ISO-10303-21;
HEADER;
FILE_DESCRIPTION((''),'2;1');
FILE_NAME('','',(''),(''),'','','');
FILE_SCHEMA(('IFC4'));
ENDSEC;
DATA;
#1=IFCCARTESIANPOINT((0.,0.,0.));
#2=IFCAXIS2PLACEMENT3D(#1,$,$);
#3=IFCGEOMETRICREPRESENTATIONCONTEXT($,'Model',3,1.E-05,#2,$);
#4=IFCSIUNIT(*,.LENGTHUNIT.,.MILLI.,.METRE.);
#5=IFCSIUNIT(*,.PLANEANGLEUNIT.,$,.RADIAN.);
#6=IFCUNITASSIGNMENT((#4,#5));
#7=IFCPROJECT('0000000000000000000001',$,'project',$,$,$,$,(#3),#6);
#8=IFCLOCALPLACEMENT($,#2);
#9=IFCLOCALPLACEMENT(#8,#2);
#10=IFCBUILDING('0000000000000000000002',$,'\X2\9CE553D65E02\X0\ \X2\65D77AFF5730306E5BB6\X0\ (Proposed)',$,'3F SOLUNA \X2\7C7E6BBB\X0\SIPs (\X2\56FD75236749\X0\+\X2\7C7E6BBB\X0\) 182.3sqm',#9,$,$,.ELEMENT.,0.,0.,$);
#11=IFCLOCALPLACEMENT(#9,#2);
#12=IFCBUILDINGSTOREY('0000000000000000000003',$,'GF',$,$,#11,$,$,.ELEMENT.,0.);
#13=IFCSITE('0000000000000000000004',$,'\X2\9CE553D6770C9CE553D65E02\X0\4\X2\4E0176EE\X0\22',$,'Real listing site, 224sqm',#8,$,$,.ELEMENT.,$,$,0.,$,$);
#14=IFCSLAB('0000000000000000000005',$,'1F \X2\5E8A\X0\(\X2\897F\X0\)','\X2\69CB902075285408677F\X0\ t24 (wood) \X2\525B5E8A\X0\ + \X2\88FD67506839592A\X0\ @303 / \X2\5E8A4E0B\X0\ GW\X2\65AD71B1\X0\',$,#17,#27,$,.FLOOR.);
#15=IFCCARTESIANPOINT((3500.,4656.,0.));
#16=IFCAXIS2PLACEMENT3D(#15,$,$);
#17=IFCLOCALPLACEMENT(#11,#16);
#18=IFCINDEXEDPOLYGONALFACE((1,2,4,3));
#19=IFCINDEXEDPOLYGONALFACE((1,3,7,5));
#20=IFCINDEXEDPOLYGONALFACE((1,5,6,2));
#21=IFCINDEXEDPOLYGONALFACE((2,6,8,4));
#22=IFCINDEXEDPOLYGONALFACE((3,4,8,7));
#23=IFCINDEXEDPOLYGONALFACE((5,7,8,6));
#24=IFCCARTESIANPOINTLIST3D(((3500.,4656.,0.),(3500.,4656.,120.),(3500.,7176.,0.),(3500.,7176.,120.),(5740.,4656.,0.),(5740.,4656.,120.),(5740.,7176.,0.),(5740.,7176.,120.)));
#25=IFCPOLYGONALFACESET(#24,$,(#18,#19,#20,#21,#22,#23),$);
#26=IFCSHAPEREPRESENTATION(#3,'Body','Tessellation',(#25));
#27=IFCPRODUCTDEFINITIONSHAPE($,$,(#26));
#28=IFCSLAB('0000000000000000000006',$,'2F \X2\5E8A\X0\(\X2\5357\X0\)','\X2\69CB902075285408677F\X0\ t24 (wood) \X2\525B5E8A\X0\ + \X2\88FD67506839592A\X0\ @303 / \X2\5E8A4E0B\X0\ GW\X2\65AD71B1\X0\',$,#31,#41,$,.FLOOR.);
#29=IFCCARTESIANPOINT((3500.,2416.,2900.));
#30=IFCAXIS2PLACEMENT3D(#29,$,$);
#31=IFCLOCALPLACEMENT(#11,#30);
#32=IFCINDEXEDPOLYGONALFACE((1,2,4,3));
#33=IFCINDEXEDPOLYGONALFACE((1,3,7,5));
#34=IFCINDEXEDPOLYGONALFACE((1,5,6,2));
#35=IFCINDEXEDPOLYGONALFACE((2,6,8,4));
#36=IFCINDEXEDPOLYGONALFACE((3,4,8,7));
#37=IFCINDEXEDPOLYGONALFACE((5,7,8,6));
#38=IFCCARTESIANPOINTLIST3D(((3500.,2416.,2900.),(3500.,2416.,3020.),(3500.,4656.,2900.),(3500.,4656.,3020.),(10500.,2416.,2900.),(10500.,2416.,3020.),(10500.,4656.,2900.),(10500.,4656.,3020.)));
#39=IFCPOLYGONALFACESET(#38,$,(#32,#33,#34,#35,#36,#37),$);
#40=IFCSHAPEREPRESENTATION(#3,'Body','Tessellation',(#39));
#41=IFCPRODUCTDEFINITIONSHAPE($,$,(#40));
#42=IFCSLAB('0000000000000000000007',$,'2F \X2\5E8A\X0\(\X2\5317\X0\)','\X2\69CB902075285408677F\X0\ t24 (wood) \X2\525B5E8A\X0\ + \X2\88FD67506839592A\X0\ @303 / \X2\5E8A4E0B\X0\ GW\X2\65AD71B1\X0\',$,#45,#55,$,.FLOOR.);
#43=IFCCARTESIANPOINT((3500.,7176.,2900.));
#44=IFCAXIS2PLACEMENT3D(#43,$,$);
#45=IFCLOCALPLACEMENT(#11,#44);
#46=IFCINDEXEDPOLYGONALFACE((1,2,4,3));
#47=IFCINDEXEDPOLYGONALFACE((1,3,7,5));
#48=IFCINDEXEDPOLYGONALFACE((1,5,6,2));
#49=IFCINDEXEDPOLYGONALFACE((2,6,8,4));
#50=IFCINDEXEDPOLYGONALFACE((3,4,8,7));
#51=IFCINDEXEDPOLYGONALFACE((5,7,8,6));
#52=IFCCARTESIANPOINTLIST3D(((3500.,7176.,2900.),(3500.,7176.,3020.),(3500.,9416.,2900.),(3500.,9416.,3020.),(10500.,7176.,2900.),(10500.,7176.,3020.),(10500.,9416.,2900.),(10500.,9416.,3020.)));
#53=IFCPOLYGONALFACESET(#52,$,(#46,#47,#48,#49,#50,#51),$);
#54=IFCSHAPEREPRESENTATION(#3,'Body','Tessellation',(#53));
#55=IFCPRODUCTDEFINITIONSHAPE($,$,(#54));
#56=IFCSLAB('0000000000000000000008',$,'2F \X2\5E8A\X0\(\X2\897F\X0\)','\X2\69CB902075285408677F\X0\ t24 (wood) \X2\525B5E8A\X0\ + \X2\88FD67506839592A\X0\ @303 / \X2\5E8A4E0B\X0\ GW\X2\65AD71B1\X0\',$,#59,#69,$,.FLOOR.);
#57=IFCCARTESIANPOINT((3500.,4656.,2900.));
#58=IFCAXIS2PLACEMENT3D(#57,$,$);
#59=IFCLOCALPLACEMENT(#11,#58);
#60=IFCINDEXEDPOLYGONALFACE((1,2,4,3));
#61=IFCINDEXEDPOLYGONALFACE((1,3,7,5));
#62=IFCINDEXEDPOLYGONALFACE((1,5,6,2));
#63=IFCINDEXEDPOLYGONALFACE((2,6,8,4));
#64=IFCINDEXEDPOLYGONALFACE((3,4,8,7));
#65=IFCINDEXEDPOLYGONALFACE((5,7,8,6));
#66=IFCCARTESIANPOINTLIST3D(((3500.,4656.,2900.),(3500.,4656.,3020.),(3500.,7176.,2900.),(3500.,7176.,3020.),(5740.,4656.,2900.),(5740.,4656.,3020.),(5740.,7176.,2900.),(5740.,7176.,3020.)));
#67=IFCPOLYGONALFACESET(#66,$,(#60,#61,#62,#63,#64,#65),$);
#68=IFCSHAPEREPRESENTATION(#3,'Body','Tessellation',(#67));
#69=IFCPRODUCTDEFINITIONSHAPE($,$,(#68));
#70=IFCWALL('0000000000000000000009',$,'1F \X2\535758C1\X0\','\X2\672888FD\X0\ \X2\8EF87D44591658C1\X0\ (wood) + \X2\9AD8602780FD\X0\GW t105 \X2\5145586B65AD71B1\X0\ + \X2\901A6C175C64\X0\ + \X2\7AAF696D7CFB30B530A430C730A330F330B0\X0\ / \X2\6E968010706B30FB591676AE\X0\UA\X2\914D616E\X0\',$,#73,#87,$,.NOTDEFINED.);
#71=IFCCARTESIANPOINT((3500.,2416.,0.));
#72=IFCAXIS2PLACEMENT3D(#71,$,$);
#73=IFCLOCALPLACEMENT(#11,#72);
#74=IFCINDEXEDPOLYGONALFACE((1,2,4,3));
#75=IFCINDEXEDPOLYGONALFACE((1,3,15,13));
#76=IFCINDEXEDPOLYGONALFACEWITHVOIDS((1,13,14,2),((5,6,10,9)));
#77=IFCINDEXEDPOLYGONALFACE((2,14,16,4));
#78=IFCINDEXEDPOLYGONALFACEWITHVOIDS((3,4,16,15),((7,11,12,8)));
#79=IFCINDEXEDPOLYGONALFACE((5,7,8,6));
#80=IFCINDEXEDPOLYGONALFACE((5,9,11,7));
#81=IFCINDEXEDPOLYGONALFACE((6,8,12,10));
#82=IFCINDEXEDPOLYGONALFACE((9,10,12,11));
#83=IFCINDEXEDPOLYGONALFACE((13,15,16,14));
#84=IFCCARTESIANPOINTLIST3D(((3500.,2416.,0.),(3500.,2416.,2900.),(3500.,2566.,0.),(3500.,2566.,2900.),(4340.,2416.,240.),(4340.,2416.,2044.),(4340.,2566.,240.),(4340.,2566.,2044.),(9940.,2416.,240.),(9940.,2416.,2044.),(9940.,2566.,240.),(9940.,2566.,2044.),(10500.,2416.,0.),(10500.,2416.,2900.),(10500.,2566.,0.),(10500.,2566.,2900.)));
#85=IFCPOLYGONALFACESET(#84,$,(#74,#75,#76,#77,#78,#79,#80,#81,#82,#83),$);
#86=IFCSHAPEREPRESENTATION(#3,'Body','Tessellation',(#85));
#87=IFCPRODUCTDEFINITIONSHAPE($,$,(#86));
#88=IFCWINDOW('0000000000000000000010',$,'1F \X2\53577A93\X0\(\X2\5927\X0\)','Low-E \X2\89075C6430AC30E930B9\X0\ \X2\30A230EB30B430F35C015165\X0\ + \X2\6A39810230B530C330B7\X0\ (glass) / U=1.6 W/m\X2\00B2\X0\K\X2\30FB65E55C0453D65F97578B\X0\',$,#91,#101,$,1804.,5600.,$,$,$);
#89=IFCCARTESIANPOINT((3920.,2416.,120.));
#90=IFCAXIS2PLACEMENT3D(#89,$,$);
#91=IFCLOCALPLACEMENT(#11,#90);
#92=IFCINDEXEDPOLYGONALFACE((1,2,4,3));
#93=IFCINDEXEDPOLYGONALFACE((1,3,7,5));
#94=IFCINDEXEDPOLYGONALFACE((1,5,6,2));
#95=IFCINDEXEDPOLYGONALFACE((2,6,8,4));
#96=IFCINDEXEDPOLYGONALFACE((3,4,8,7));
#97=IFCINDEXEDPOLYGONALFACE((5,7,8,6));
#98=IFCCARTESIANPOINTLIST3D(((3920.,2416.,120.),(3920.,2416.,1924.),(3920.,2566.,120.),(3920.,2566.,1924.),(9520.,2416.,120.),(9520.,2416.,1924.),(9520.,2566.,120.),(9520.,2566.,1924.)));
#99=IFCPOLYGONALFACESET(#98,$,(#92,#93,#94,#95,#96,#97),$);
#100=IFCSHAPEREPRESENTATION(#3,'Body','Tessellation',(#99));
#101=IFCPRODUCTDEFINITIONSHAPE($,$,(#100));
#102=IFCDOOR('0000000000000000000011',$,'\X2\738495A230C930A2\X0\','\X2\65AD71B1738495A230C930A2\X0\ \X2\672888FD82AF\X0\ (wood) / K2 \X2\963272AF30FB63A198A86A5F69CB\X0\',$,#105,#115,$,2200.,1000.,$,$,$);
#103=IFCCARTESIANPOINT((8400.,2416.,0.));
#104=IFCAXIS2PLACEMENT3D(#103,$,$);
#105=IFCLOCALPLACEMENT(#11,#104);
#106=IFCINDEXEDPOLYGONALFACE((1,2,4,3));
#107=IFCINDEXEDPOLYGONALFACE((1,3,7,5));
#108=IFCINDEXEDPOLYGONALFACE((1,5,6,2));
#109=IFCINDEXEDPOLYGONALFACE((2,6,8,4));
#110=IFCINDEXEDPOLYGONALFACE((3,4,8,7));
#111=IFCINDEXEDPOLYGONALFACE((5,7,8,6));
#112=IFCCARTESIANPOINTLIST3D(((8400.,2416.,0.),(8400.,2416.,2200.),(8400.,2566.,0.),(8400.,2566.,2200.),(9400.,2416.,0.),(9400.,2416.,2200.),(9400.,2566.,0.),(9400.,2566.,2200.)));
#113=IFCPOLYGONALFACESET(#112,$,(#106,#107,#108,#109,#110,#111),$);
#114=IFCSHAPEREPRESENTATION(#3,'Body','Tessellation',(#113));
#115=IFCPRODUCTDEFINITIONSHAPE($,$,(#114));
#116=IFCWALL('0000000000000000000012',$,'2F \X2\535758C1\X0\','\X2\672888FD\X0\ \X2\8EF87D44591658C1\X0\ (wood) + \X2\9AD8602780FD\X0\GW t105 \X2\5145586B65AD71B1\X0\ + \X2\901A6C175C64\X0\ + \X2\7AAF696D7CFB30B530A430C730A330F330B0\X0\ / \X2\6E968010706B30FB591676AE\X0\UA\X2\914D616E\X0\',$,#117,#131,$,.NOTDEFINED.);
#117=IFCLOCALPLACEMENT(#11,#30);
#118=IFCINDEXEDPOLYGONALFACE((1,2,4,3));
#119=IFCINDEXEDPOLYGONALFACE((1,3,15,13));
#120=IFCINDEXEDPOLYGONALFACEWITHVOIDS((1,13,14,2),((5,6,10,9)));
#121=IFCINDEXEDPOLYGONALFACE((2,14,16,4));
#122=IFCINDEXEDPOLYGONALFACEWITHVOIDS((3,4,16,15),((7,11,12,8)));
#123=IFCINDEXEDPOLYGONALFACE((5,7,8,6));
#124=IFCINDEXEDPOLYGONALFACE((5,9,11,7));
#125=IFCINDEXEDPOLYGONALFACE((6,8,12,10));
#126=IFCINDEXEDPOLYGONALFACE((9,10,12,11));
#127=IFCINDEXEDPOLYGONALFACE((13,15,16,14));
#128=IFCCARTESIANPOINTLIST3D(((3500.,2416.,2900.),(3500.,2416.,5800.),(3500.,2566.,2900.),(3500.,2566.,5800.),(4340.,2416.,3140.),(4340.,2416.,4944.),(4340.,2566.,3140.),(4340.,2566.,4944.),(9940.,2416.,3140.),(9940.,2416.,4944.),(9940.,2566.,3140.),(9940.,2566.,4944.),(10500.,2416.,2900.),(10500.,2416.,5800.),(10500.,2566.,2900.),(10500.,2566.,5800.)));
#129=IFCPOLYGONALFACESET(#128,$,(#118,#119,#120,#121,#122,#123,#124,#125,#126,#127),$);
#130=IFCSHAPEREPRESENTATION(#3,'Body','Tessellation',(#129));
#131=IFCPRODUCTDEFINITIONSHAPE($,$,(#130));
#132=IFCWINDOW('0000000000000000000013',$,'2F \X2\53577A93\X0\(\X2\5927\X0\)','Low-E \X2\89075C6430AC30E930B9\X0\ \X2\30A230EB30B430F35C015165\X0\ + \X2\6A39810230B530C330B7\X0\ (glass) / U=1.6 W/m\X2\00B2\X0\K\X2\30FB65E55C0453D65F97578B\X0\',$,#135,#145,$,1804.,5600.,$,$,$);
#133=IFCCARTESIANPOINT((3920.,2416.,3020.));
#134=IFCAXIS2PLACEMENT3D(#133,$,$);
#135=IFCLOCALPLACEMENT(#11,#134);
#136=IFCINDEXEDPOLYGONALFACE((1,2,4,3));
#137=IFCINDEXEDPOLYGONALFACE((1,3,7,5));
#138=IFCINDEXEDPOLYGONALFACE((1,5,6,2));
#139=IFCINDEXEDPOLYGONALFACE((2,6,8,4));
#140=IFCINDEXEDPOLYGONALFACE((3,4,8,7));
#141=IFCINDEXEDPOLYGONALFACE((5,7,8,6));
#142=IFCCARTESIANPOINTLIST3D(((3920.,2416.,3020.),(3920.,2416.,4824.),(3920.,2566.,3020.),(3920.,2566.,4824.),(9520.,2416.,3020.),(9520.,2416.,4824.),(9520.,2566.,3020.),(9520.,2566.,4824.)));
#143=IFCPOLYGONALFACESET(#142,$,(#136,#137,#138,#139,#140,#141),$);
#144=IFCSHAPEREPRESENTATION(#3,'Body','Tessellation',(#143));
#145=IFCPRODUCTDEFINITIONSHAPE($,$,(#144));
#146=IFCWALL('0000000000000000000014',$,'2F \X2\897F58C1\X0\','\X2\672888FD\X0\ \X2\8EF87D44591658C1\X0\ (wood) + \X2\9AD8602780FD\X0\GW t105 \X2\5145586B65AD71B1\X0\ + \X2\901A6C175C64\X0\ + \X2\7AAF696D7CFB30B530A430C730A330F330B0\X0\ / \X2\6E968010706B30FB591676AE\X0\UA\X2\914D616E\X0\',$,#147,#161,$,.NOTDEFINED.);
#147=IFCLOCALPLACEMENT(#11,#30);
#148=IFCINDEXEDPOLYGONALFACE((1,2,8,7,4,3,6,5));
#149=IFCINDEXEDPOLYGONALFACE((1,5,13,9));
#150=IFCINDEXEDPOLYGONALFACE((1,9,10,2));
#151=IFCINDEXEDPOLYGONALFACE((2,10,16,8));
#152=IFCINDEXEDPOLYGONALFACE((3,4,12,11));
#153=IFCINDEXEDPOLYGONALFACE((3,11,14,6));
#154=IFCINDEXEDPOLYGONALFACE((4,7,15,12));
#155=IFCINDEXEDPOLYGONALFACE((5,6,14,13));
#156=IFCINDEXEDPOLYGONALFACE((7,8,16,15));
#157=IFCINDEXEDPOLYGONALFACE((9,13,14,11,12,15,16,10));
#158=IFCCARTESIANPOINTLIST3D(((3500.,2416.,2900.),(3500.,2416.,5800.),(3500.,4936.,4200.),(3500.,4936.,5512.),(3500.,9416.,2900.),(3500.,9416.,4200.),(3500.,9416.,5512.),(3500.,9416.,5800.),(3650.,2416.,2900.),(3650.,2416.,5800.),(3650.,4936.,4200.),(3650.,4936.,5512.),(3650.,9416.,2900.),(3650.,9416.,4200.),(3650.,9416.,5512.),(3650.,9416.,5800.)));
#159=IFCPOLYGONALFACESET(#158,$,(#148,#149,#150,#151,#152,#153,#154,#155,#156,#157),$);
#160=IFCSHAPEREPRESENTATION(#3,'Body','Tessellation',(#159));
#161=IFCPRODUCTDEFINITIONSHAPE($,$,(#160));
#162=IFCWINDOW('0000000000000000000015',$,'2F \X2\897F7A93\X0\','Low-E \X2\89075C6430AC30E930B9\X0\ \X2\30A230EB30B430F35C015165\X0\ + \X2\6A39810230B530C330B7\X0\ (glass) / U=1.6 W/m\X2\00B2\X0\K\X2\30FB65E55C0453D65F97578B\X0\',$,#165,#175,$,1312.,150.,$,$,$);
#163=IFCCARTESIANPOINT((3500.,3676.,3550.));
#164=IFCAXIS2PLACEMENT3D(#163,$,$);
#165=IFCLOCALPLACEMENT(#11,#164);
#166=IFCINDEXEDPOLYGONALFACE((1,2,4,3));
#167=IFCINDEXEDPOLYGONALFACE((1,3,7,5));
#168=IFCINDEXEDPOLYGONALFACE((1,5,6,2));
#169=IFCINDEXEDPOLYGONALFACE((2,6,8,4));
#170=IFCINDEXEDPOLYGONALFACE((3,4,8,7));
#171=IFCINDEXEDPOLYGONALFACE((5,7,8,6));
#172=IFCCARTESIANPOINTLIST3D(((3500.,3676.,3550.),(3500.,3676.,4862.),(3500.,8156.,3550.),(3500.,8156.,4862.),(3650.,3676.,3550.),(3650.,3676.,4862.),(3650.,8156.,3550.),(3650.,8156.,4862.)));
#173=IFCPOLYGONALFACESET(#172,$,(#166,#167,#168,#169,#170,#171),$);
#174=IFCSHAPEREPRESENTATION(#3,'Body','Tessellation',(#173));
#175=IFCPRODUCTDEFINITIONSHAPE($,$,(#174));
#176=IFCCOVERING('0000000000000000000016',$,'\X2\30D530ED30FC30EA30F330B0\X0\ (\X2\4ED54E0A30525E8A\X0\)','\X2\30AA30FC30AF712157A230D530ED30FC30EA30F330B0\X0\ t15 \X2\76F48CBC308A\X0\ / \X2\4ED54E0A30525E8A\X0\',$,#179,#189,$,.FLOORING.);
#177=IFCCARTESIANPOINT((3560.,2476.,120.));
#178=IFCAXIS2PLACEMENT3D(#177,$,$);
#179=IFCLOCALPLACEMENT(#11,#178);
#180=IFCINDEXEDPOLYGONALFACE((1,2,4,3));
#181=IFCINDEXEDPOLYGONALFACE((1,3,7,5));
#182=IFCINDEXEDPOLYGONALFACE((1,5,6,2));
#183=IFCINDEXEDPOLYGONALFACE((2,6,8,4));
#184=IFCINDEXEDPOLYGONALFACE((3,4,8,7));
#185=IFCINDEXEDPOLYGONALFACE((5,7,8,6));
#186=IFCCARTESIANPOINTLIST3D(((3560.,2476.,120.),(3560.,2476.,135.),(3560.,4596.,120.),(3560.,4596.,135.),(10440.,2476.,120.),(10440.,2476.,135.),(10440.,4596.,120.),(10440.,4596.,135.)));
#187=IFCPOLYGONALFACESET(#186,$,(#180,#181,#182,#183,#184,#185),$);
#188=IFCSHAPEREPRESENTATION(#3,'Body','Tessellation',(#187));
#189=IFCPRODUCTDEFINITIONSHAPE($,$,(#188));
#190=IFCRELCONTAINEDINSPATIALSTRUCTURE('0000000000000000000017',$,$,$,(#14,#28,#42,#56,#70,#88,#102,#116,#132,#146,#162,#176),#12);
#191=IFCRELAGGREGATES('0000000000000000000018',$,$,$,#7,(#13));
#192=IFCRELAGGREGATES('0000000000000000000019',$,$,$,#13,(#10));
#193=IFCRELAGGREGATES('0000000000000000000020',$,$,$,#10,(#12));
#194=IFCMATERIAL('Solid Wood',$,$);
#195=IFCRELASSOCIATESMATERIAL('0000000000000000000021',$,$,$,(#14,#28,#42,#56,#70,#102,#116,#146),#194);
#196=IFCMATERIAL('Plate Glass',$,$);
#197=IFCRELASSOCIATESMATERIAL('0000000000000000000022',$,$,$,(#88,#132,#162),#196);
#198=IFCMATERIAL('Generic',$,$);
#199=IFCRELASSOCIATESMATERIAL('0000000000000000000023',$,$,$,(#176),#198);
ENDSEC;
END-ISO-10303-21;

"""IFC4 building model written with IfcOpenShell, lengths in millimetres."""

from ifc_helpers import new_model, si_unit, frame, frame_2d, origin, place, context, project, spatial, rectangle, extrude, material, element, fill, save


model = new_model("IFC4")

# Units and contexts
model_context = context("Model", 3, precision=1e-05, world=origin())
ifc_project = project(units=[si_unit("LENGTHUNIT", "METRE", prefix="MILLI"), si_unit("PLANEANGLEUNIT", "RADIAN")], contexts=[model_context])

# Site, building, storey
site_placement = place(None, origin())
site = spatial("IfcSite", under=ifc_project, at=site_placement, Name="鳥取県鳥取市4丁目22", ObjectType="Real listing site, 224sqm", CompositionType="ELEMENT", RefElevation=0.0)
building_placement = place(site_placement, origin())
building = spatial("IfcBuilding", under=site, at=building_placement, Name="鳥取市 旗竿地の家 (Proposed)", ObjectType="3F SOLUNA 籾殻SIPs (国産杉+籾殻) 182.3sqm", CompositionType="ELEMENT", ElevationOfRefHeight=0.0, ElevationOfTerrain=0.0)
storey_placement = place(building_placement, origin())
storey = spatial("IfcBuildingStorey", under=building, at=storey_placement, Name="GF", CompositionType="ELEMENT", Elevation=0.0)

# Slabs
ifc_material_1 = material(Name="Solid Wood")
slab_1_placement = place(storey_placement, frame((3500.0, 4656.0, 0.0)))
element("IfcSlab", 1, at=slab_1_placement, inside=storey, material=ifc_material_1, Name="1F 床(西)", Description="構造用合板 t24 (wood) 剛床 + 製材根太 @303 / 床下 GW断熱", PredefinedType="FLOOR", context=model_context, shape_type="SweptSolid", body=[
    extrude(rectangle(XDim=2240.0, YDim=2520.0, at=frame_2d((1120.0, 1260.0))), frame((3500.0, 4656.0, 0.0)), (0.0, 0.0, 1.0), 120.0),
])
slab_2_placement = place(storey_placement, frame((3500.0, 2416.0, 2900.0)))
element("IfcSlab", 2, at=slab_2_placement, inside=storey, material=ifc_material_1, Name="2F 床(南)", Description="構造用合板 t24 (wood) 剛床 + 製材根太 @303 / 床下 GW断熱", PredefinedType="FLOOR", context=model_context, shape_type="SweptSolid", body=[
    extrude(rectangle(XDim=7000.0, YDim=2240.0, at=frame_2d((3500.0, 1120.0))), frame((3500.0, 2416.0, 2900.0)), (0.0, 0.0, 1.0), 120.0),
])
slab_3_placement = place(storey_placement, frame((3500.0, 7176.0, 2900.0)))
element("IfcSlab", 3, at=slab_3_placement, inside=storey, material=ifc_material_1, Name="2F 床(北)", Description="構造用合板 t24 (wood) 剛床 + 製材根太 @303 / 床下 GW断熱", PredefinedType="FLOOR", context=model_context, shape_type="SweptSolid", body=[
    extrude(rectangle(XDim=7000.0, YDim=2240.0, at=frame_2d((3500.0, 1120.0))), frame((3500.0, 7176.0, 2900.0)), (0.0, 0.0, 1.0), 120.0),
])
slab_4_placement = place(storey_placement, frame((3500.0, 4656.0, 2900.0)))
element("IfcSlab", 4, at=slab_4_placement, inside=storey, material=ifc_material_1, Name="2F 床(西)", Description="構造用合板 t24 (wood) 剛床 + 製材根太 @303 / 床下 GW断熱", PredefinedType="FLOOR", context=model_context, shape_type="SweptSolid", body=[
    extrude(rectangle(XDim=2240.0, YDim=2520.0, at=frame_2d((1120.0, 1260.0))), frame((3500.0, 4656.0, 2900.0)), (0.0, 0.0, 1.0), 120.0),
])

# Wall, openings, window, door
wall_1_placement = place(storey_placement, frame((3500.0, 2416.0, 0.0)))
wall_1 = element("IfcWall", 5, at=wall_1_placement, inside=storey, material=ifc_material_1, Name="1F 南壁", Description="木製 軸組外壁 (wood) + 高性能GW t105 充填断熱 + 通気層 + 窯業系サイディング / 準耐火・外皮UA配慮", PredefinedType="NOTDEFINED", context=model_context, shape_type="SweptSolid", body=[
    extrude(rectangle(XDim=7000.0, YDim=150.0, at=frame_2d((3500.0, 75.0))), frame((3500.0, 2416.0, 0.0)), (0.0, 0.0, 1.0), 2900.0),
])
opening_1_placement = place(storey_placement, frame((3920.0, 2416.0, 120.0)))
opening_1 = element("IfcOpeningElement", 6, at=opening_1_placement, cuts=wall_1, PredefinedType="NOTDEFINED", context=model_context, shape_type="SweptSolid", body=[
    extrude(rectangle(XDim=5600.0, YDim=150.0, at=frame_2d((2800.0, 75.0))), frame((3920.0, 2416.0, 120.0)), (0.0, 0.0, 1.0), 1804.0),
])
opening_2_placement = place(storey_placement, frame((8400.0, 2416.0, 0.0)))
opening_2 = element("IfcOpeningElement", 7, at=opening_2_placement, cuts=wall_1, PredefinedType="NOTDEFINED", context=model_context, shape_type="SweptSolid", body=[
    extrude(rectangle(XDim=1000.0, YDim=150.0, at=frame_2d((500.0, 75.0))), frame((8400.0, 2416.0, 0.0)), (0.0, 0.0, 1.0), 2200.0),
])
ifc_material_2 = material(Name="Plate Glass")
window_1_placement = place(storey_placement, frame((3920.0, 2416.0, 120.0)))
window_1 = element("IfcWindow", 8, at=window_1_placement, inside=storey, material=ifc_material_2, Name="1F 南窓(大)", Description="Low-E 複層ガラス アルゴン封入 + 樹脂サッシ (glass) / U=1.6 W/m²K・日射取得型", OverallHeight=1804.0, OverallWidth=5600.0, context=model_context, shape_type="SweptSolid", body=[
    extrude(rectangle(XDim=5600.0, YDim=150.0, at=frame_2d((2800.0, 75.0))), frame((3920.0, 2416.0, 120.0)), (0.0, 0.0, 1.0), 1804.0),
])
fill(opening_1, window_1)
door_placement = place(storey_placement, frame((8400.0, 2416.0, 0.0)))
door = element("IfcDoor", 9, at=door_placement, inside=storey, material=ifc_material_1, Name="玄関ドア", Description="断熱玄関ドア 木製芯 (wood) / K2 防犯・採風機構", OverallHeight=2200.0, OverallWidth=1000.0, context=model_context, shape_type="SweptSolid", body=[
    extrude(rectangle(XDim=1000.0, YDim=150.0, at=frame_2d((500.0, 75.0))), frame((8400.0, 2416.0, 0.0)), (0.0, 0.0, 1.0), 2200.0),
])
fill(opening_2, door)

# Wall, opening, window
wall_2_placement = place(storey_placement, frame((3500.0, 2416.0, 2900.0)))
wall_2 = element("IfcWall", 10, at=wall_2_placement, inside=storey, material=ifc_material_1, Name="2F 南壁", Description="木製 軸組外壁 (wood) + 高性能GW t105 充填断熱 + 通気層 + 窯業系サイディング / 準耐火・外皮UA配慮", PredefinedType="NOTDEFINED", context=model_context, shape_type="SweptSolid", body=[
    extrude(rectangle(XDim=7000.0, YDim=150.0, at=frame_2d((3500.0, 75.0))), frame((3500.0, 2416.0, 2900.0)), (0.0, 0.0, 1.0), 2900.0),
])
opening_3_placement = place(storey_placement, frame((3920.0, 2416.0, 3020.0)))
opening_3 = element("IfcOpeningElement", 11, at=opening_3_placement, cuts=wall_2, PredefinedType="NOTDEFINED", context=model_context, shape_type="SweptSolid", body=[
    extrude(rectangle(XDim=5600.0, YDim=150.0, at=frame_2d((2800.0, 75.0))), frame((3920.0, 2416.0, 3020.0)), (0.0, 0.0, 1.0), 1804.0),
])
window_2_placement = place(storey_placement, frame((3920.0, 2416.0, 3020.0)))
window_2 = element("IfcWindow", 12, at=window_2_placement, inside=storey, material=ifc_material_2, Name="2F 南窓(大)", Description="Low-E 複層ガラス アルゴン封入 + 樹脂サッシ (glass) / U=1.6 W/m²K・日射取得型", OverallHeight=1804.0, OverallWidth=5600.0, context=model_context, shape_type="SweptSolid", body=[
    extrude(rectangle(XDim=5600.0, YDim=150.0, at=frame_2d((2800.0, 75.0))), frame((3920.0, 2416.0, 3020.0)), (0.0, 0.0, 1.0), 1804.0),
])
fill(opening_3, window_2)

# Wall, opening, window
wall_3_placement = place(storey_placement, frame((3500.0, 2416.0, 2900.0)))
wall_3 = element("IfcWall", 13, at=wall_3_placement, inside=storey, material=ifc_material_1, Name="2F 西壁", Description="木製 軸組外壁 (wood) + 高性能GW t105 充填断熱 + 通気層 + 窯業系サイディング / 準耐火・外皮UA配慮", PredefinedType="NOTDEFINED", context=model_context, shape_type="SweptSolid", body=[
    extrude(rectangle(XDim=150.0, YDim=7000.0, at=frame_2d((75.0, 3500.0))), frame((3500.0, 2416.0, 2900.0)), (0.0, 0.0, 1.0), 2900.0),
])
opening_4_placement = place(storey_placement, frame((3500.0, 3676.0, 3550.0)))
opening_4 = element("IfcOpeningElement", 14, at=opening_4_placement, cuts=wall_3, PredefinedType="NOTDEFINED", context=model_context, shape_type="SweptSolid", body=[
    extrude(rectangle(XDim=150.0, YDim=4480.0, at=frame_2d((75.0, 2240.0))), frame((3500.0, 3676.0, 3550.0)), (0.0, 0.0, 1.0), 1312.0),
])
window_3_placement = place(storey_placement, frame((3500.0, 3676.0, 3550.0)))
window_3 = element("IfcWindow", 15, at=window_3_placement, inside=storey, material=ifc_material_2, Name="2F 西窓", Description="Low-E 複層ガラス アルゴン封入 + 樹脂サッシ (glass) / U=1.6 W/m²K・日射取得型", OverallHeight=1312.0, OverallWidth=150.0, context=model_context, shape_type="SweptSolid", body=[
    extrude(rectangle(XDim=150.0, YDim=4480.0, at=frame_2d((75.0, 2240.0))), frame((3500.0, 3676.0, 3550.0)), (0.0, 0.0, 1.0), 1312.0),
])
fill(opening_4, window_3)

# Covering
ifc_material_3 = material(Name="Generic")
covering_1_placement = place(storey_placement, frame((3560.0, 2476.0, 120.0)))
element("IfcCovering", 16, at=covering_1_placement, inside=storey, material=ifc_material_3, Name="フローリング (仕上げ床)", Description="オーク無垢フローリング t15 直貼り / 仕上げ床", PredefinedType="FLOORING", context=model_context, shape_type="SweptSolid", body=[
    extrude(rectangle(XDim=6880.0, YDim=2120.0, at=frame_2d((3440.0, 1060.0))), frame((3560.0, 2476.0, 120.0)), (0.0, 0.0, 1.0), 15.0),
])

save(model, "model.ifc")
